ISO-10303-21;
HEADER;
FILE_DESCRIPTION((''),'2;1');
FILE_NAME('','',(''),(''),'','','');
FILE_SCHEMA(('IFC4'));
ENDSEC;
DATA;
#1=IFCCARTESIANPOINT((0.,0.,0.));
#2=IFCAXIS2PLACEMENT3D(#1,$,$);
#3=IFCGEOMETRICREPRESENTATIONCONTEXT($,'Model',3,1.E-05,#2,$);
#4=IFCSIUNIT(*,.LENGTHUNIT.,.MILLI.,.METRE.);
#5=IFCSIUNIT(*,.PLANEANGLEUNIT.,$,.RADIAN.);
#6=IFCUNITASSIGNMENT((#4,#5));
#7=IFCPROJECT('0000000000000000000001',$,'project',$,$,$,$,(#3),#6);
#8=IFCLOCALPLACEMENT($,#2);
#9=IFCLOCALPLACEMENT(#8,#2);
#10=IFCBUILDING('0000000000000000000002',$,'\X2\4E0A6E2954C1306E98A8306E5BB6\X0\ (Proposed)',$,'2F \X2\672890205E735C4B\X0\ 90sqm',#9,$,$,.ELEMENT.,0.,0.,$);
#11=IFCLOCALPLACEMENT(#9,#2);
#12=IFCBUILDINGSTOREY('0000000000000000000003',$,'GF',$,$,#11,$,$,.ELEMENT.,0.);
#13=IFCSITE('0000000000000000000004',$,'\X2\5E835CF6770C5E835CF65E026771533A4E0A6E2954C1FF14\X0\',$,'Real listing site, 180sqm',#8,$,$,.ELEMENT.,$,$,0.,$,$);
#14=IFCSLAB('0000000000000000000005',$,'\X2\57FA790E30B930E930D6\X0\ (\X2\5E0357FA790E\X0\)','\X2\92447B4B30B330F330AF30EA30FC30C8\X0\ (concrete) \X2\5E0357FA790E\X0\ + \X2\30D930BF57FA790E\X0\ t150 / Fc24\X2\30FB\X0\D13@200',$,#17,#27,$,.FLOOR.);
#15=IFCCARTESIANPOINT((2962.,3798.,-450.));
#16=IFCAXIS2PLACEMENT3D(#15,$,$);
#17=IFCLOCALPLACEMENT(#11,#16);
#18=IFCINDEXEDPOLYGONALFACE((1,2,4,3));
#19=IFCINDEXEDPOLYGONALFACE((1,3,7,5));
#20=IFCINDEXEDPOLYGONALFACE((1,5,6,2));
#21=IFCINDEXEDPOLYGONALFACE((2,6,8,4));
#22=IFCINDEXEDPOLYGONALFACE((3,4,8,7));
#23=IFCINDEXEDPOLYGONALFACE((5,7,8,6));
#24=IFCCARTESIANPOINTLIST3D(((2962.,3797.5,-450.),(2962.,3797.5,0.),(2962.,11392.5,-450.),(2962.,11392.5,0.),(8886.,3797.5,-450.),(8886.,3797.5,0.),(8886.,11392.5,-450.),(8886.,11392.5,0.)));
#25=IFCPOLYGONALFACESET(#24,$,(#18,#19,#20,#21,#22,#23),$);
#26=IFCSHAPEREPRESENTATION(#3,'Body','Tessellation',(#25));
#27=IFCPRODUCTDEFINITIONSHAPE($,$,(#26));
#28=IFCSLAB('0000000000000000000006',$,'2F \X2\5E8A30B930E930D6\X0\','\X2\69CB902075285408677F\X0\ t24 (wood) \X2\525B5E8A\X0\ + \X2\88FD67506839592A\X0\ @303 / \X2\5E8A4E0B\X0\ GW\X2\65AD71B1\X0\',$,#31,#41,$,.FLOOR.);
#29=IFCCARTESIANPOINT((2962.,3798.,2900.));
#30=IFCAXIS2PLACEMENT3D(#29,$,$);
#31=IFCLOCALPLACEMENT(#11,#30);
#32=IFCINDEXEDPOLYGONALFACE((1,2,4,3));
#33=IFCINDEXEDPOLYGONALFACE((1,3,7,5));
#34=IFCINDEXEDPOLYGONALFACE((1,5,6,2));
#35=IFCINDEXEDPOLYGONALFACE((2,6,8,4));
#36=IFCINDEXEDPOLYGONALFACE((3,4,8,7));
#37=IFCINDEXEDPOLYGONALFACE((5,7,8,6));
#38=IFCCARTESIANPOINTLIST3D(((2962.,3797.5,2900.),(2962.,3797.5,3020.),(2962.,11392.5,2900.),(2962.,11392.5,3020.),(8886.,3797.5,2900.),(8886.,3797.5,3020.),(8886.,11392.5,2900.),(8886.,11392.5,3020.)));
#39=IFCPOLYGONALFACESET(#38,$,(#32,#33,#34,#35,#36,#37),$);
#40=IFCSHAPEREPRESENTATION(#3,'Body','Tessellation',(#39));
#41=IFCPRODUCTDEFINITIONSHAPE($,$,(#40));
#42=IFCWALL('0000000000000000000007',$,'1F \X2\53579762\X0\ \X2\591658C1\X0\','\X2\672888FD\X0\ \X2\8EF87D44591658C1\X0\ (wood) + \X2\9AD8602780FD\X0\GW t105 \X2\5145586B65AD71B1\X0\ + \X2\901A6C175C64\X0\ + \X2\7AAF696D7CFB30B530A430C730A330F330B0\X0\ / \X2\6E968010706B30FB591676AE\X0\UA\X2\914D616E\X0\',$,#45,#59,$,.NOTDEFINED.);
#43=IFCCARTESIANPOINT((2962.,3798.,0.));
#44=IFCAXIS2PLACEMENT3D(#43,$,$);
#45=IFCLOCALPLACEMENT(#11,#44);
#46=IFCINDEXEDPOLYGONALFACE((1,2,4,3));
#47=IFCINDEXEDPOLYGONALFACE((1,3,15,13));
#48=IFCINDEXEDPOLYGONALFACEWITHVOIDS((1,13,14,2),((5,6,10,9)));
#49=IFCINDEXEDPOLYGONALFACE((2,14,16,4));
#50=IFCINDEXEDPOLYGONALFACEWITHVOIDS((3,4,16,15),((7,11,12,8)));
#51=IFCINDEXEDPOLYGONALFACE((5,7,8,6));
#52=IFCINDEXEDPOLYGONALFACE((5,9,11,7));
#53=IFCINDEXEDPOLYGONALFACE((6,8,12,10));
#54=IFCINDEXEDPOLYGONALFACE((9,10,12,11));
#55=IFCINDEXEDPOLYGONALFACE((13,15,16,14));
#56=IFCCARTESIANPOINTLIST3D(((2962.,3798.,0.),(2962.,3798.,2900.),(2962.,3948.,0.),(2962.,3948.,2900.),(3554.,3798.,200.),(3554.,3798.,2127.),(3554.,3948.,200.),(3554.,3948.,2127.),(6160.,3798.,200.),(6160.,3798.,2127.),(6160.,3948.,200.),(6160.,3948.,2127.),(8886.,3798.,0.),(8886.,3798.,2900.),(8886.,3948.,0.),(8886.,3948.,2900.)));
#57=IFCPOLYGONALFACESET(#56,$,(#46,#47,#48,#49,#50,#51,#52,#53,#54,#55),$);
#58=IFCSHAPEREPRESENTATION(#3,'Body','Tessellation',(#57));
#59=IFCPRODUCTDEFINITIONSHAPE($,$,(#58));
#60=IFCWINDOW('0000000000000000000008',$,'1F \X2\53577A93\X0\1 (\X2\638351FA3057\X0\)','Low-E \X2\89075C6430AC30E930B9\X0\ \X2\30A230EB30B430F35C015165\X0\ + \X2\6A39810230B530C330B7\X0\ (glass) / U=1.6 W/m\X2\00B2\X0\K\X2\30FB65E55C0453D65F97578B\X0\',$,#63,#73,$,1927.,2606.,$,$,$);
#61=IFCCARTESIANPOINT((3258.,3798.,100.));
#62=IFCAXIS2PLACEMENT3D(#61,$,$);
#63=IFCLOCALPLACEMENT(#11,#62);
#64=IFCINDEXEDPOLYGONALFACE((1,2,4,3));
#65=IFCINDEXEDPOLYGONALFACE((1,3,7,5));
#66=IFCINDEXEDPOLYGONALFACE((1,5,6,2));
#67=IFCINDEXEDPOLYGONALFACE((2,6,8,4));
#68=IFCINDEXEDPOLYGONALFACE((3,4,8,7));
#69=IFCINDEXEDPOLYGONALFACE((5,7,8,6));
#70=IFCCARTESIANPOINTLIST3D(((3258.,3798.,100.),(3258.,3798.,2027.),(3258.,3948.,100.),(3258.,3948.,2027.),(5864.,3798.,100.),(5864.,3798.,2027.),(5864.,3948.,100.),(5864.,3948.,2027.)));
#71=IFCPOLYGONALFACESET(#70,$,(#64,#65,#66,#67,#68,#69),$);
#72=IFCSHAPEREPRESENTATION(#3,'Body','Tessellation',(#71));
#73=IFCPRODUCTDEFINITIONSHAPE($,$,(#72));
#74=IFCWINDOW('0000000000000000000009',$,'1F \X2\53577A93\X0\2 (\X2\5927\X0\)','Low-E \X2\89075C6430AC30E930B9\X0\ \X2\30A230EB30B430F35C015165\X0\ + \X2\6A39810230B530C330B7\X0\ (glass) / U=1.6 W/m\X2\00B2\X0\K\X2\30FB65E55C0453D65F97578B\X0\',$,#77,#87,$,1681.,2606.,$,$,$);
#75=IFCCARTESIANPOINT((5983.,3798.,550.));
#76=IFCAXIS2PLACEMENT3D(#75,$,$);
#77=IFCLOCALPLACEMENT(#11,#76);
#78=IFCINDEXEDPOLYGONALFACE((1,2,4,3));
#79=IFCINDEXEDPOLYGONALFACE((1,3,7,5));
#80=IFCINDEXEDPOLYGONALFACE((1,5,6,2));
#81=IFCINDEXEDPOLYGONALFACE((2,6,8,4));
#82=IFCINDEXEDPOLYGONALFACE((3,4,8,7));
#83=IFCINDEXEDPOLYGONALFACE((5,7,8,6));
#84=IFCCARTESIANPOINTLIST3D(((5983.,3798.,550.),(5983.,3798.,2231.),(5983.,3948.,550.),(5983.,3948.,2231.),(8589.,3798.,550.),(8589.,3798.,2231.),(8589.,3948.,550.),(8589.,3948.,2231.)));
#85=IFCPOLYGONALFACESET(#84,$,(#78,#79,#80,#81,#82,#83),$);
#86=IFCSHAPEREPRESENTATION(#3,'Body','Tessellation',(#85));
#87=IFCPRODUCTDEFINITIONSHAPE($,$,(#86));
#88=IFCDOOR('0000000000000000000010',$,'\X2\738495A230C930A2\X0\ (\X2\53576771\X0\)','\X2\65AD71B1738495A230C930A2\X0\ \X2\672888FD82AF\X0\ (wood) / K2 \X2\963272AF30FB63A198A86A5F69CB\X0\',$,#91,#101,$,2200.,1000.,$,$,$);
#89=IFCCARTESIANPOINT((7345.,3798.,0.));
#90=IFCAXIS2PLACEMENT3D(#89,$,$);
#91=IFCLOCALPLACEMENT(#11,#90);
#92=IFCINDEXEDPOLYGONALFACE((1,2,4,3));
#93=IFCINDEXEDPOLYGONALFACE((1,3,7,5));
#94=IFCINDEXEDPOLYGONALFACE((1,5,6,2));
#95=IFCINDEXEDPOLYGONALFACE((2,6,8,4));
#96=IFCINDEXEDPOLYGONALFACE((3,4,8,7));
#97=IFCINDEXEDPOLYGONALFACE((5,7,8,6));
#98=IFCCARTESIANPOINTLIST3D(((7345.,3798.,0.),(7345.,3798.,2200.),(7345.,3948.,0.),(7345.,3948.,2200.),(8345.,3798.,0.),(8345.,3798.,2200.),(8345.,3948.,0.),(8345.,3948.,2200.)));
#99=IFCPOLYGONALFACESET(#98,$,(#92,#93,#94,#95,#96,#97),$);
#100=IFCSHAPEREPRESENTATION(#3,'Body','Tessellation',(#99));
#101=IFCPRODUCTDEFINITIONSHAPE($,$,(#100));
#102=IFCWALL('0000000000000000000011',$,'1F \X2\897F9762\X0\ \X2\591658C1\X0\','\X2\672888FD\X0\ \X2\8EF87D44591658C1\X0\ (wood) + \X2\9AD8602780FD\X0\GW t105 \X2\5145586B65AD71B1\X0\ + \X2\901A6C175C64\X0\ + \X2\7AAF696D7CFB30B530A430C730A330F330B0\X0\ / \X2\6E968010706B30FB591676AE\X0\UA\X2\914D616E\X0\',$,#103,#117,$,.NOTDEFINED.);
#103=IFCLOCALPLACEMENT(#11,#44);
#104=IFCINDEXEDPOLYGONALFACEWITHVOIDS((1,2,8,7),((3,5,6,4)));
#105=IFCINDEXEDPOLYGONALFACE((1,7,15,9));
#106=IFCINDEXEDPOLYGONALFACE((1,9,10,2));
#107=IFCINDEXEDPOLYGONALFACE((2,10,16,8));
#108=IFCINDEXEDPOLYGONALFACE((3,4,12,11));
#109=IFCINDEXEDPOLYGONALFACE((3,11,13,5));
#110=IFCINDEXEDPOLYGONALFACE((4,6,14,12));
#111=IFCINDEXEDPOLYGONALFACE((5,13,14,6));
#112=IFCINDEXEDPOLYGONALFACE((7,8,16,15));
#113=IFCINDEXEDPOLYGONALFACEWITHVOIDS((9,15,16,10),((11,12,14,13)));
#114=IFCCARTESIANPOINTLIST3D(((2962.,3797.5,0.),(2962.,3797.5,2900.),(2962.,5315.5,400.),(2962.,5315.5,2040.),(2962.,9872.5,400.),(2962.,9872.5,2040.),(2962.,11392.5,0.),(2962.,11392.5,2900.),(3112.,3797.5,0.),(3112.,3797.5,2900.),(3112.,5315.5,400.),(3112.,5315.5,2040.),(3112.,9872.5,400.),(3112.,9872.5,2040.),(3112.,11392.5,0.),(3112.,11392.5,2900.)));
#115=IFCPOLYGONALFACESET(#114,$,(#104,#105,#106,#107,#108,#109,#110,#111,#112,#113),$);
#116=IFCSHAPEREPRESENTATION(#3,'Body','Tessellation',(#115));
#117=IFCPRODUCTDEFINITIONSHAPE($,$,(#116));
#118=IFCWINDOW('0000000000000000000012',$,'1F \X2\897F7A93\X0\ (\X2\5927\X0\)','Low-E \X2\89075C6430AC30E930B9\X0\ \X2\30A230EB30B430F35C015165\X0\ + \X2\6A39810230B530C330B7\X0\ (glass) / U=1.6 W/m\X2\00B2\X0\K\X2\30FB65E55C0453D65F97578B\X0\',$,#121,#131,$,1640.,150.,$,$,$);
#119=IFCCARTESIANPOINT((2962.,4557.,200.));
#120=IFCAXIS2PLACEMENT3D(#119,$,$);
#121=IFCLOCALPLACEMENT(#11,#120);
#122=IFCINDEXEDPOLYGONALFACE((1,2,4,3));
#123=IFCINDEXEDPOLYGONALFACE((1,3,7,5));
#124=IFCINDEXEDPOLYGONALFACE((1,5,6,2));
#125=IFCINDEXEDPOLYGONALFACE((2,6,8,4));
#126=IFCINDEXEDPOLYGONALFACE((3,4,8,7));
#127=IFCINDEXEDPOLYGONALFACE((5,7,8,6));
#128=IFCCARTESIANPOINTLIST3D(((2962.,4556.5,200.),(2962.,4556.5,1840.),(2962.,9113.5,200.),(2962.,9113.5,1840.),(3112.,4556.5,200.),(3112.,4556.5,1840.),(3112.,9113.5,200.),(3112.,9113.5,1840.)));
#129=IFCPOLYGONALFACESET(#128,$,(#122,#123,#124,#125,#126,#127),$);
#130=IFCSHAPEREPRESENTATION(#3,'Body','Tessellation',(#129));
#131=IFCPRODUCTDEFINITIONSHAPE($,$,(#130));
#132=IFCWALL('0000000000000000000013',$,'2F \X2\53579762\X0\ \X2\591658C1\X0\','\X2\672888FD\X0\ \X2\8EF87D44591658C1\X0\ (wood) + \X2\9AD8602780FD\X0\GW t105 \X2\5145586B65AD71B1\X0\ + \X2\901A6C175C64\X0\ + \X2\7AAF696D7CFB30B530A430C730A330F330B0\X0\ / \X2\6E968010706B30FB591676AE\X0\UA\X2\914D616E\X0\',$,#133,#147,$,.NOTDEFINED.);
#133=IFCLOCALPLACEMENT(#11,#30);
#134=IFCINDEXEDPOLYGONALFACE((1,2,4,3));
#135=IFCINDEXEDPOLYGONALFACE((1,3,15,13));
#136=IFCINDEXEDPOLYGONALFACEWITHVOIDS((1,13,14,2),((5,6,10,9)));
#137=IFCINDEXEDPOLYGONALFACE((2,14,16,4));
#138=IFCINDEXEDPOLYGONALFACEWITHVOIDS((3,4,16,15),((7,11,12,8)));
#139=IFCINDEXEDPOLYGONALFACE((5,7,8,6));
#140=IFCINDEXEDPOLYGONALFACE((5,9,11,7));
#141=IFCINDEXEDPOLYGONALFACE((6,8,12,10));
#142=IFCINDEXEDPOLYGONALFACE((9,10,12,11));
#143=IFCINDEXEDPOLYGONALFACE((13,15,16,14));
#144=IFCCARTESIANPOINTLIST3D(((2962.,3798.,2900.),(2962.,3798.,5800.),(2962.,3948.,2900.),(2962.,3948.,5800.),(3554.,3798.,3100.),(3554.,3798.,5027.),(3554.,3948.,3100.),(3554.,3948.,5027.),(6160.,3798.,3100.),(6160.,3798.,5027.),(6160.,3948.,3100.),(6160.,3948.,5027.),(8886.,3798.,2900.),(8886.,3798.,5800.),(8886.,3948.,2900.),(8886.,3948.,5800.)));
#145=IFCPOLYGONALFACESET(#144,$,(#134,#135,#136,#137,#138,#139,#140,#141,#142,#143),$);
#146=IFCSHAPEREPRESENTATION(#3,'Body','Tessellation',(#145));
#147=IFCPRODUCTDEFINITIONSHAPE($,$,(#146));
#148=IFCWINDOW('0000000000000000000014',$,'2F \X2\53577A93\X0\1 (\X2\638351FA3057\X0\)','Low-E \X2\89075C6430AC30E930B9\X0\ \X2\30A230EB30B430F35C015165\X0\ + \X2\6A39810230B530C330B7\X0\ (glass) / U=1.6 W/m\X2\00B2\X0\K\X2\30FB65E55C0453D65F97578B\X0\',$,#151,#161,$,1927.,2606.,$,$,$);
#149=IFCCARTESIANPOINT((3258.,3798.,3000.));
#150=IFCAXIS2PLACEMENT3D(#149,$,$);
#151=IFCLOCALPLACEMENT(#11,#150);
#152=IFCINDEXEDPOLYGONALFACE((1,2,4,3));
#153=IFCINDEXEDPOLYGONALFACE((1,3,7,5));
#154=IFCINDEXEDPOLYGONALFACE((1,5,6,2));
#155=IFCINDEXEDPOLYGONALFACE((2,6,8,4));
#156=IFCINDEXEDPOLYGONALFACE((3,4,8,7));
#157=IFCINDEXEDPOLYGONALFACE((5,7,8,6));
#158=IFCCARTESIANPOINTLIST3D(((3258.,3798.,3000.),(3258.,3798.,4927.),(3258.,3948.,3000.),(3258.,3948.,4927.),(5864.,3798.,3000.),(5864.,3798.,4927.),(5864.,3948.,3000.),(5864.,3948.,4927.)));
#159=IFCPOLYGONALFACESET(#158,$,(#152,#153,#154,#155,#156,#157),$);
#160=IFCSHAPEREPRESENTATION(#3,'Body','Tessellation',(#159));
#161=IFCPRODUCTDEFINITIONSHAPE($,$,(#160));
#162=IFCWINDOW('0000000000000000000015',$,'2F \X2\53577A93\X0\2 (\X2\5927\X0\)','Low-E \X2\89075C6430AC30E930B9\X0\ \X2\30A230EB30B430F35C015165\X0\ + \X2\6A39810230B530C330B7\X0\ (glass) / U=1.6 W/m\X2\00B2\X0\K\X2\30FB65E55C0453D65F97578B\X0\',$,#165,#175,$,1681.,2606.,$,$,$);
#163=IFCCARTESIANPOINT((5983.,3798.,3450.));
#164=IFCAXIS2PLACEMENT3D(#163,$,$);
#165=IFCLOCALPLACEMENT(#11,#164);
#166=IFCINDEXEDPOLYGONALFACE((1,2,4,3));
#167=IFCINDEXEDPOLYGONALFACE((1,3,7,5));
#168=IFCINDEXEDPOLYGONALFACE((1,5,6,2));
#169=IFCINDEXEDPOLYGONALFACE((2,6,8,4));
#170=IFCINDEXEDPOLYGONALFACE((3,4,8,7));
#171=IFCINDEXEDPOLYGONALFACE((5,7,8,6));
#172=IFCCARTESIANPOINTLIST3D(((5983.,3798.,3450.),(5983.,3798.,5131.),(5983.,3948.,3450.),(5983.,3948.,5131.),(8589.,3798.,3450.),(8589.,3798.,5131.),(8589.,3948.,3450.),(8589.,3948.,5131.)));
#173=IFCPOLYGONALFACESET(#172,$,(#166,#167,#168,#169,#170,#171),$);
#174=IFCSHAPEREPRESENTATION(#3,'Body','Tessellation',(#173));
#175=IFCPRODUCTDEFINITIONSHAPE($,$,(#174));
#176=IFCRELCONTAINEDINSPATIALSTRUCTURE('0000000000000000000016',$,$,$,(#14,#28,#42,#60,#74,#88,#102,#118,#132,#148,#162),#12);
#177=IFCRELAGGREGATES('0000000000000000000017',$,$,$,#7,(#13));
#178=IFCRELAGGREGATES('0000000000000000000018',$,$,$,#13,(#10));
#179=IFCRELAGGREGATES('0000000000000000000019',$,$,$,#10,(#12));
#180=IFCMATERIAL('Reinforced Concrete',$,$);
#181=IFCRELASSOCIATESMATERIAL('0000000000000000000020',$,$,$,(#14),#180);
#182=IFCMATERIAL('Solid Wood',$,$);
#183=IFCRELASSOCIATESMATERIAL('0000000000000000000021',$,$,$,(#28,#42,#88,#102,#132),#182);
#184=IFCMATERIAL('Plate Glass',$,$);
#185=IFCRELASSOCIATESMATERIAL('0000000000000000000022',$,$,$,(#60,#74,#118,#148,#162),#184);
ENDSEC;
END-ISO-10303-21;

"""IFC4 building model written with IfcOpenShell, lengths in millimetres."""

from ifc_helpers import new_model, si_unit, frame, frame_2d, origin, place, context, project, spatial, rectangle, extrude, material, element, fill, save


model = new_model("IFC4")

# Units and contexts
model_context = context("Model", 3, precision=1e-05, world=origin())
ifc_project = project(units=[si_unit("LENGTHUNIT", "METRE", prefix="MILLI"), si_unit("PLANEANGLEUNIT", "RADIAN")], contexts=[model_context])

# Site, building, storey
site_placement = place(None, origin())
site = spatial("IfcSite", under=ifc_project, at=site_placement, Name="広島県広島市東区上温品４", ObjectType="Real listing site, 180sqm", CompositionType="ELEMENT", RefElevation=0.0)
building_placement = place(site_placement, origin())
building = spatial("IfcBuilding", under=site, at=building_placement, Name="上温品の風の家 (Proposed)", ObjectType="2F 木造平屋 90sqm", CompositionType="ELEMENT", ElevationOfRefHeight=0.0, ElevationOfTerrain=0.0)
storey_placement = place(building_placement, origin())
storey = spatial("IfcBuildingStorey", under=building, at=storey_placement, Name="GF", CompositionType="ELEMENT", Elevation=0.0)

# Slabs
ifc_material_1 = material(Name="Reinforced Concrete")
slab_1_placement = place(storey_placement, frame((2962.0, 3798.0, -450.0)))
element("IfcSlab", 1, at=slab_1_placement, inside=storey, material=ifc_material_1, Name="基礎スラブ (布基礎)", Description="鉄筋コンクリート (concrete) 布基礎 + ベタ基礎 t150 / Fc24・D13@200", PredefinedType="FLOOR", context=model_context, shape_type="SweptSolid", body=[
    extrude(rectangle(XDim=5924.0, YDim=7595.0, at=frame_2d((2962.0, 3797.0))), frame((2962.0, 3798.0, -450.0)), (0.0, 0.0, 1.0), 450.0),
])
ifc_material_2 = material(Name="Solid Wood")
slab_2_placement = place(storey_placement, frame((2962.0, 3798.0, 2900.0)))
element("IfcSlab", 2, at=slab_2_placement, inside=storey, material=ifc_material_2, Name="2F 床スラブ", Description="構造用合板 t24 (wood) 剛床 + 製材根太 @303 / 床下 GW断熱", PredefinedType="FLOOR", context=model_context, shape_type="SweptSolid", body=[
    extrude(rectangle(XDim=5924.0, YDim=7595.0, at=frame_2d((2962.0, 3797.0))), frame((2962.0, 3798.0, 2900.0)), (0.0, 0.0, 1.0), 120.0),
])

# Wall, openings, windows, door
wall_1_placement = place(storey_placement, frame((2962.0, 3798.0, 0.0)))
wall_1 = element("IfcWall", 3, at=wall_1_placement, inside=storey, material=ifc_material_2, Name="1F 南面 外壁", Description="木製 軸組外壁 (wood) + 高性能GW t105 充填断熱 + 通気層 + 窯業系サイディング / 準耐火・外皮UA配慮", PredefinedType="NOTDEFINED", context=model_context, shape_type="SweptSolid", body=[
    extrude(rectangle(XDim=5924.0, YDim=150.0, at=frame_2d((2962.0, 75.0))), frame((2962.0, 3798.0, 0.0)), (0.0, 0.0, 1.0), 2900.0),
])
opening_1_placement = place(storey_placement, frame((3258.0, 3798.0, 100.0)))
opening_1 = element("IfcOpeningElement", 4, at=opening_1_placement, cuts=wall_1, PredefinedType="NOTDEFINED", context=model_context, shape_type="SweptSolid", body=[
    extrude(rectangle(XDim=2606.0, YDim=150.0, at=frame_2d((1303.0, 75.0))), frame((3258.0, 3798.0, 100.0)), (0.0, 0.0, 1.0), 1927.0),
])
opening_2_placement = place(storey_placement, frame((5983.0, 3798.0, 550.0)))
opening_2 = element("IfcOpeningElement", 5, at=opening_2_placement, cuts=wall_1, PredefinedType="NOTDEFINED", context=model_context, shape_type="SweptSolid", body=[
    extrude(rectangle(XDim=2606.0, YDim=150.0, at=frame_2d((1303.0, 75.0))), frame((5983.0, 3798.0, 550.0)), (0.0, 0.0, 1.0), 1681.0),
])
opening_3_placement = place(storey_placement, frame((7345.0, 3798.0, 0.0)))
opening_3 = element("IfcOpeningElement", 6, at=opening_3_placement, cuts=wall_1, PredefinedType="NOTDEFINED", context=model_context, shape_type="SweptSolid", body=[
    extrude(rectangle(XDim=1000.0, YDim=150.0, at=frame_2d((500.0, 75.0))), frame((7345.0, 3798.0, 0.0)), (0.0, 0.0, 1.0), 2200.0),
])
ifc_material_3 = material(Name="Plate Glass")
window_1_placement = place(storey_placement, frame((3258.0, 3798.0, 100.0)))
window_1 = element("IfcWindow", 7, at=window_1_placement, inside=storey, material=ifc_material_3, Name="1F 南窓1 (掃出し)", Description="Low-E 複層ガラス アルゴン封入 + 樹脂サッシ (glass) / U=1.6 W/m²K・日射取得型", OverallHeight=1927.0, OverallWidth=2606.0, context=model_context, shape_type="SweptSolid", body=[
    extrude(rectangle(XDim=2606.0, YDim=150.0, at=frame_2d((1303.0, 75.0))), frame((3258.0, 3798.0, 100.0)), (0.0, 0.0, 1.0), 1927.0),
])
fill(opening_1, window_1)
window_2_placement = place(storey_placement, frame((5983.0, 3798.0, 550.0)))
window_2 = element("IfcWindow", 8, at=window_2_placement, inside=storey, material=ifc_material_3, Name="1F 南窓2 (大)", Description="Low-E 複層ガラス アルゴン封入 + 樹脂サッシ (glass) / U=1.6 W/m²K・日射取得型", OverallHeight=1681.0, OverallWidth=2606.0, context=model_context, shape_type="SweptSolid", body=[
    extrude(rectangle(XDim=2606.0, YDim=150.0, at=frame_2d((1303.0, 75.0))), frame((5983.0, 3798.0, 550.0)), (0.0, 0.0, 1.0), 1681.0),
])
fill(opening_2, window_2)
door_placement = place(storey_placement, frame((7345.0, 3798.0, 0.0)))
door = element("IfcDoor", 9, at=door_placement, inside=storey, material=ifc_material_2, Name="玄関ドア (南東)", Description="断熱玄関ドア 木製芯 (wood) / K2 防犯・採風機構", OverallHeight=2200.0, OverallWidth=1000.0, context=model_context, shape_type="SweptSolid", body=[
    extrude(rectangle(XDim=1000.0, YDim=150.0, at=frame_2d((500.0, 75.0))), frame((7345.0, 3798.0, 0.0)), (0.0, 0.0, 1.0), 2200.0),
])
fill(opening_3, door)

# Wall, opening, window
wall_2_placement = place(storey_placement, frame((2962.0, 3798.0, 0.0)))
wall_2 = element("IfcWall", 10, at=wall_2_placement, inside=storey, material=ifc_material_2, Name="1F 西面 外壁", Description="木製 軸組外壁 (wood) + 高性能GW t105 充填断熱 + 通気層 + 窯業系サイディング / 準耐火・外皮UA配慮", PredefinedType="NOTDEFINED", context=model_context, shape_type="SweptSolid", body=[
    extrude(rectangle(XDim=150.0, YDim=7595.0, at=frame_2d((75.0, 3797.0))), frame((2962.0, 3798.0, 0.0)), (0.0, 0.0, 1.0), 2900.0),
])
opening_4_placement = place(storey_placement, frame((2962.0, 4557.0, 200.0)))
opening_4 = element("IfcOpeningElement", 11, at=opening_4_placement, cuts=wall_2, PredefinedType="NOTDEFINED", context=model_context, shape_type="SweptSolid", body=[
    extrude(rectangle(XDim=150.0, YDim=4557.0, at=frame_2d((75.0, 2278.0))), frame((2962.0, 4557.0, 200.0)), (0.0, 0.0, 1.0), 1640.0),
])
window_3_placement = place(storey_placement, frame((2962.0, 4557.0, 200.0)))
window_3 = element("IfcWindow", 12, at=window_3_placement, inside=storey, material=ifc_material_3, Name="1F 西窓 (大)", Description="Low-E 複層ガラス アルゴン封入 + 樹脂サッシ (glass) / U=1.6 W/m²K・日射取得型", OverallHeight=1640.0, OverallWidth=150.0, context=model_context, shape_type="SweptSolid", body=[
    extrude(rectangle(XDim=150.0, YDim=4557.0, at=frame_2d((75.0, 2278.0))), frame((2962.0, 4557.0, 200.0)), (0.0, 0.0, 1.0), 1640.0),
])
fill(opening_4, window_3)

# Wall, openings, windows
wall_3_placement = place(storey_placement, frame((2962.0, 3798.0, 2900.0)))
wall_3 = element("IfcWall", 13, at=wall_3_placement, inside=storey, material=ifc_material_2, Name="2F 南面 外壁", Description="木製 軸組外壁 (wood) + 高性能GW t105 充填断熱 + 通気層 + 窯業系サイディング / 準耐火・外皮UA配慮", PredefinedType="NOTDEFINED", context=model_context, shape_type="SweptSolid", body=[
    extrude(rectangle(XDim=5924.0, YDim=150.0, at=frame_2d((2962.0, 75.0))), frame((2962.0, 3798.0, 2900.0)), (0.0, 0.0, 1.0), 2900.0),
])
opening_5_placement = place(storey_placement, frame((3258.0, 3798.0, 3000.0)))
opening_5 = element("IfcOpeningElement", 14, at=opening_5_placement, cuts=wall_3, PredefinedType="NOTDEFINED", context=model_context, shape_type="SweptSolid", body=[
    extrude(rectangle(XDim=2606.0, YDim=150.0, at=frame_2d((1303.0, 75.0))), frame((3258.0, 3798.0, 3000.0)), (0.0, 0.0, 1.0), 1927.0),
])
opening_6_placement = place(storey_placement, frame((5983.0, 3798.0, 3450.0)))
opening_6 = element("IfcOpeningElement", 15, at=opening_6_placement, cuts=wall_3, PredefinedType="NOTDEFINED", context=model_context, shape_type="SweptSolid", body=[
    extrude(rectangle(XDim=2606.0, YDim=150.0, at=frame_2d((1303.0, 75.0))), frame((5983.0, 3798.0, 3450.0)), (0.0, 0.0, 1.0), 1681.0),
])
window_4_placement = place(storey_placement, frame((3258.0, 3798.0, 3000.0)))
window_4 = element("IfcWindow", 16, at=window_4_placement, inside=storey, material=ifc_material_3, Name="2F 南窓1 (掃出し)", Description="Low-E 複層ガラス アルゴン封入 + 樹脂サッシ (glass) / U=1.6 W/m²K・日射取得型", OverallHeight=1927.0, OverallWidth=2606.0, context=model_context, shape_type="SweptSolid", body=[
    extrude(rectangle(XDim=2606.0, YDim=150.0, at=frame_2d((1303.0, 75.0))), frame((3258.0, 3798.0, 3000.0)), (0.0, 0.0, 1.0), 1927.0),
])
fill(opening_5, window_4)
window_5_placement = place(storey_placement, frame((5983.0, 3798.0, 3450.0)))
window_5 = element("IfcWindow", 17, at=window_5_placement, inside=storey, material=ifc_material_3, Name="2F 南窓2 (大)", Description="Low-E 複層ガラス アルゴン封入 + 樹脂サッシ (glass) / U=1.6 W/m²K・日射取得型", OverallHeight=1681.0, OverallWidth=2606.0, context=model_context, shape_type="SweptSolid", body=[
    extrude(rectangle(XDim=2606.0, YDim=150.0, at=frame_2d((1303.0, 75.0))), frame((5983.0, 3798.0, 3450.0)), (0.0, 0.0, 1.0), 1681.0),
])
fill(opening_6, window_5)

save(model, "model.ifc")
